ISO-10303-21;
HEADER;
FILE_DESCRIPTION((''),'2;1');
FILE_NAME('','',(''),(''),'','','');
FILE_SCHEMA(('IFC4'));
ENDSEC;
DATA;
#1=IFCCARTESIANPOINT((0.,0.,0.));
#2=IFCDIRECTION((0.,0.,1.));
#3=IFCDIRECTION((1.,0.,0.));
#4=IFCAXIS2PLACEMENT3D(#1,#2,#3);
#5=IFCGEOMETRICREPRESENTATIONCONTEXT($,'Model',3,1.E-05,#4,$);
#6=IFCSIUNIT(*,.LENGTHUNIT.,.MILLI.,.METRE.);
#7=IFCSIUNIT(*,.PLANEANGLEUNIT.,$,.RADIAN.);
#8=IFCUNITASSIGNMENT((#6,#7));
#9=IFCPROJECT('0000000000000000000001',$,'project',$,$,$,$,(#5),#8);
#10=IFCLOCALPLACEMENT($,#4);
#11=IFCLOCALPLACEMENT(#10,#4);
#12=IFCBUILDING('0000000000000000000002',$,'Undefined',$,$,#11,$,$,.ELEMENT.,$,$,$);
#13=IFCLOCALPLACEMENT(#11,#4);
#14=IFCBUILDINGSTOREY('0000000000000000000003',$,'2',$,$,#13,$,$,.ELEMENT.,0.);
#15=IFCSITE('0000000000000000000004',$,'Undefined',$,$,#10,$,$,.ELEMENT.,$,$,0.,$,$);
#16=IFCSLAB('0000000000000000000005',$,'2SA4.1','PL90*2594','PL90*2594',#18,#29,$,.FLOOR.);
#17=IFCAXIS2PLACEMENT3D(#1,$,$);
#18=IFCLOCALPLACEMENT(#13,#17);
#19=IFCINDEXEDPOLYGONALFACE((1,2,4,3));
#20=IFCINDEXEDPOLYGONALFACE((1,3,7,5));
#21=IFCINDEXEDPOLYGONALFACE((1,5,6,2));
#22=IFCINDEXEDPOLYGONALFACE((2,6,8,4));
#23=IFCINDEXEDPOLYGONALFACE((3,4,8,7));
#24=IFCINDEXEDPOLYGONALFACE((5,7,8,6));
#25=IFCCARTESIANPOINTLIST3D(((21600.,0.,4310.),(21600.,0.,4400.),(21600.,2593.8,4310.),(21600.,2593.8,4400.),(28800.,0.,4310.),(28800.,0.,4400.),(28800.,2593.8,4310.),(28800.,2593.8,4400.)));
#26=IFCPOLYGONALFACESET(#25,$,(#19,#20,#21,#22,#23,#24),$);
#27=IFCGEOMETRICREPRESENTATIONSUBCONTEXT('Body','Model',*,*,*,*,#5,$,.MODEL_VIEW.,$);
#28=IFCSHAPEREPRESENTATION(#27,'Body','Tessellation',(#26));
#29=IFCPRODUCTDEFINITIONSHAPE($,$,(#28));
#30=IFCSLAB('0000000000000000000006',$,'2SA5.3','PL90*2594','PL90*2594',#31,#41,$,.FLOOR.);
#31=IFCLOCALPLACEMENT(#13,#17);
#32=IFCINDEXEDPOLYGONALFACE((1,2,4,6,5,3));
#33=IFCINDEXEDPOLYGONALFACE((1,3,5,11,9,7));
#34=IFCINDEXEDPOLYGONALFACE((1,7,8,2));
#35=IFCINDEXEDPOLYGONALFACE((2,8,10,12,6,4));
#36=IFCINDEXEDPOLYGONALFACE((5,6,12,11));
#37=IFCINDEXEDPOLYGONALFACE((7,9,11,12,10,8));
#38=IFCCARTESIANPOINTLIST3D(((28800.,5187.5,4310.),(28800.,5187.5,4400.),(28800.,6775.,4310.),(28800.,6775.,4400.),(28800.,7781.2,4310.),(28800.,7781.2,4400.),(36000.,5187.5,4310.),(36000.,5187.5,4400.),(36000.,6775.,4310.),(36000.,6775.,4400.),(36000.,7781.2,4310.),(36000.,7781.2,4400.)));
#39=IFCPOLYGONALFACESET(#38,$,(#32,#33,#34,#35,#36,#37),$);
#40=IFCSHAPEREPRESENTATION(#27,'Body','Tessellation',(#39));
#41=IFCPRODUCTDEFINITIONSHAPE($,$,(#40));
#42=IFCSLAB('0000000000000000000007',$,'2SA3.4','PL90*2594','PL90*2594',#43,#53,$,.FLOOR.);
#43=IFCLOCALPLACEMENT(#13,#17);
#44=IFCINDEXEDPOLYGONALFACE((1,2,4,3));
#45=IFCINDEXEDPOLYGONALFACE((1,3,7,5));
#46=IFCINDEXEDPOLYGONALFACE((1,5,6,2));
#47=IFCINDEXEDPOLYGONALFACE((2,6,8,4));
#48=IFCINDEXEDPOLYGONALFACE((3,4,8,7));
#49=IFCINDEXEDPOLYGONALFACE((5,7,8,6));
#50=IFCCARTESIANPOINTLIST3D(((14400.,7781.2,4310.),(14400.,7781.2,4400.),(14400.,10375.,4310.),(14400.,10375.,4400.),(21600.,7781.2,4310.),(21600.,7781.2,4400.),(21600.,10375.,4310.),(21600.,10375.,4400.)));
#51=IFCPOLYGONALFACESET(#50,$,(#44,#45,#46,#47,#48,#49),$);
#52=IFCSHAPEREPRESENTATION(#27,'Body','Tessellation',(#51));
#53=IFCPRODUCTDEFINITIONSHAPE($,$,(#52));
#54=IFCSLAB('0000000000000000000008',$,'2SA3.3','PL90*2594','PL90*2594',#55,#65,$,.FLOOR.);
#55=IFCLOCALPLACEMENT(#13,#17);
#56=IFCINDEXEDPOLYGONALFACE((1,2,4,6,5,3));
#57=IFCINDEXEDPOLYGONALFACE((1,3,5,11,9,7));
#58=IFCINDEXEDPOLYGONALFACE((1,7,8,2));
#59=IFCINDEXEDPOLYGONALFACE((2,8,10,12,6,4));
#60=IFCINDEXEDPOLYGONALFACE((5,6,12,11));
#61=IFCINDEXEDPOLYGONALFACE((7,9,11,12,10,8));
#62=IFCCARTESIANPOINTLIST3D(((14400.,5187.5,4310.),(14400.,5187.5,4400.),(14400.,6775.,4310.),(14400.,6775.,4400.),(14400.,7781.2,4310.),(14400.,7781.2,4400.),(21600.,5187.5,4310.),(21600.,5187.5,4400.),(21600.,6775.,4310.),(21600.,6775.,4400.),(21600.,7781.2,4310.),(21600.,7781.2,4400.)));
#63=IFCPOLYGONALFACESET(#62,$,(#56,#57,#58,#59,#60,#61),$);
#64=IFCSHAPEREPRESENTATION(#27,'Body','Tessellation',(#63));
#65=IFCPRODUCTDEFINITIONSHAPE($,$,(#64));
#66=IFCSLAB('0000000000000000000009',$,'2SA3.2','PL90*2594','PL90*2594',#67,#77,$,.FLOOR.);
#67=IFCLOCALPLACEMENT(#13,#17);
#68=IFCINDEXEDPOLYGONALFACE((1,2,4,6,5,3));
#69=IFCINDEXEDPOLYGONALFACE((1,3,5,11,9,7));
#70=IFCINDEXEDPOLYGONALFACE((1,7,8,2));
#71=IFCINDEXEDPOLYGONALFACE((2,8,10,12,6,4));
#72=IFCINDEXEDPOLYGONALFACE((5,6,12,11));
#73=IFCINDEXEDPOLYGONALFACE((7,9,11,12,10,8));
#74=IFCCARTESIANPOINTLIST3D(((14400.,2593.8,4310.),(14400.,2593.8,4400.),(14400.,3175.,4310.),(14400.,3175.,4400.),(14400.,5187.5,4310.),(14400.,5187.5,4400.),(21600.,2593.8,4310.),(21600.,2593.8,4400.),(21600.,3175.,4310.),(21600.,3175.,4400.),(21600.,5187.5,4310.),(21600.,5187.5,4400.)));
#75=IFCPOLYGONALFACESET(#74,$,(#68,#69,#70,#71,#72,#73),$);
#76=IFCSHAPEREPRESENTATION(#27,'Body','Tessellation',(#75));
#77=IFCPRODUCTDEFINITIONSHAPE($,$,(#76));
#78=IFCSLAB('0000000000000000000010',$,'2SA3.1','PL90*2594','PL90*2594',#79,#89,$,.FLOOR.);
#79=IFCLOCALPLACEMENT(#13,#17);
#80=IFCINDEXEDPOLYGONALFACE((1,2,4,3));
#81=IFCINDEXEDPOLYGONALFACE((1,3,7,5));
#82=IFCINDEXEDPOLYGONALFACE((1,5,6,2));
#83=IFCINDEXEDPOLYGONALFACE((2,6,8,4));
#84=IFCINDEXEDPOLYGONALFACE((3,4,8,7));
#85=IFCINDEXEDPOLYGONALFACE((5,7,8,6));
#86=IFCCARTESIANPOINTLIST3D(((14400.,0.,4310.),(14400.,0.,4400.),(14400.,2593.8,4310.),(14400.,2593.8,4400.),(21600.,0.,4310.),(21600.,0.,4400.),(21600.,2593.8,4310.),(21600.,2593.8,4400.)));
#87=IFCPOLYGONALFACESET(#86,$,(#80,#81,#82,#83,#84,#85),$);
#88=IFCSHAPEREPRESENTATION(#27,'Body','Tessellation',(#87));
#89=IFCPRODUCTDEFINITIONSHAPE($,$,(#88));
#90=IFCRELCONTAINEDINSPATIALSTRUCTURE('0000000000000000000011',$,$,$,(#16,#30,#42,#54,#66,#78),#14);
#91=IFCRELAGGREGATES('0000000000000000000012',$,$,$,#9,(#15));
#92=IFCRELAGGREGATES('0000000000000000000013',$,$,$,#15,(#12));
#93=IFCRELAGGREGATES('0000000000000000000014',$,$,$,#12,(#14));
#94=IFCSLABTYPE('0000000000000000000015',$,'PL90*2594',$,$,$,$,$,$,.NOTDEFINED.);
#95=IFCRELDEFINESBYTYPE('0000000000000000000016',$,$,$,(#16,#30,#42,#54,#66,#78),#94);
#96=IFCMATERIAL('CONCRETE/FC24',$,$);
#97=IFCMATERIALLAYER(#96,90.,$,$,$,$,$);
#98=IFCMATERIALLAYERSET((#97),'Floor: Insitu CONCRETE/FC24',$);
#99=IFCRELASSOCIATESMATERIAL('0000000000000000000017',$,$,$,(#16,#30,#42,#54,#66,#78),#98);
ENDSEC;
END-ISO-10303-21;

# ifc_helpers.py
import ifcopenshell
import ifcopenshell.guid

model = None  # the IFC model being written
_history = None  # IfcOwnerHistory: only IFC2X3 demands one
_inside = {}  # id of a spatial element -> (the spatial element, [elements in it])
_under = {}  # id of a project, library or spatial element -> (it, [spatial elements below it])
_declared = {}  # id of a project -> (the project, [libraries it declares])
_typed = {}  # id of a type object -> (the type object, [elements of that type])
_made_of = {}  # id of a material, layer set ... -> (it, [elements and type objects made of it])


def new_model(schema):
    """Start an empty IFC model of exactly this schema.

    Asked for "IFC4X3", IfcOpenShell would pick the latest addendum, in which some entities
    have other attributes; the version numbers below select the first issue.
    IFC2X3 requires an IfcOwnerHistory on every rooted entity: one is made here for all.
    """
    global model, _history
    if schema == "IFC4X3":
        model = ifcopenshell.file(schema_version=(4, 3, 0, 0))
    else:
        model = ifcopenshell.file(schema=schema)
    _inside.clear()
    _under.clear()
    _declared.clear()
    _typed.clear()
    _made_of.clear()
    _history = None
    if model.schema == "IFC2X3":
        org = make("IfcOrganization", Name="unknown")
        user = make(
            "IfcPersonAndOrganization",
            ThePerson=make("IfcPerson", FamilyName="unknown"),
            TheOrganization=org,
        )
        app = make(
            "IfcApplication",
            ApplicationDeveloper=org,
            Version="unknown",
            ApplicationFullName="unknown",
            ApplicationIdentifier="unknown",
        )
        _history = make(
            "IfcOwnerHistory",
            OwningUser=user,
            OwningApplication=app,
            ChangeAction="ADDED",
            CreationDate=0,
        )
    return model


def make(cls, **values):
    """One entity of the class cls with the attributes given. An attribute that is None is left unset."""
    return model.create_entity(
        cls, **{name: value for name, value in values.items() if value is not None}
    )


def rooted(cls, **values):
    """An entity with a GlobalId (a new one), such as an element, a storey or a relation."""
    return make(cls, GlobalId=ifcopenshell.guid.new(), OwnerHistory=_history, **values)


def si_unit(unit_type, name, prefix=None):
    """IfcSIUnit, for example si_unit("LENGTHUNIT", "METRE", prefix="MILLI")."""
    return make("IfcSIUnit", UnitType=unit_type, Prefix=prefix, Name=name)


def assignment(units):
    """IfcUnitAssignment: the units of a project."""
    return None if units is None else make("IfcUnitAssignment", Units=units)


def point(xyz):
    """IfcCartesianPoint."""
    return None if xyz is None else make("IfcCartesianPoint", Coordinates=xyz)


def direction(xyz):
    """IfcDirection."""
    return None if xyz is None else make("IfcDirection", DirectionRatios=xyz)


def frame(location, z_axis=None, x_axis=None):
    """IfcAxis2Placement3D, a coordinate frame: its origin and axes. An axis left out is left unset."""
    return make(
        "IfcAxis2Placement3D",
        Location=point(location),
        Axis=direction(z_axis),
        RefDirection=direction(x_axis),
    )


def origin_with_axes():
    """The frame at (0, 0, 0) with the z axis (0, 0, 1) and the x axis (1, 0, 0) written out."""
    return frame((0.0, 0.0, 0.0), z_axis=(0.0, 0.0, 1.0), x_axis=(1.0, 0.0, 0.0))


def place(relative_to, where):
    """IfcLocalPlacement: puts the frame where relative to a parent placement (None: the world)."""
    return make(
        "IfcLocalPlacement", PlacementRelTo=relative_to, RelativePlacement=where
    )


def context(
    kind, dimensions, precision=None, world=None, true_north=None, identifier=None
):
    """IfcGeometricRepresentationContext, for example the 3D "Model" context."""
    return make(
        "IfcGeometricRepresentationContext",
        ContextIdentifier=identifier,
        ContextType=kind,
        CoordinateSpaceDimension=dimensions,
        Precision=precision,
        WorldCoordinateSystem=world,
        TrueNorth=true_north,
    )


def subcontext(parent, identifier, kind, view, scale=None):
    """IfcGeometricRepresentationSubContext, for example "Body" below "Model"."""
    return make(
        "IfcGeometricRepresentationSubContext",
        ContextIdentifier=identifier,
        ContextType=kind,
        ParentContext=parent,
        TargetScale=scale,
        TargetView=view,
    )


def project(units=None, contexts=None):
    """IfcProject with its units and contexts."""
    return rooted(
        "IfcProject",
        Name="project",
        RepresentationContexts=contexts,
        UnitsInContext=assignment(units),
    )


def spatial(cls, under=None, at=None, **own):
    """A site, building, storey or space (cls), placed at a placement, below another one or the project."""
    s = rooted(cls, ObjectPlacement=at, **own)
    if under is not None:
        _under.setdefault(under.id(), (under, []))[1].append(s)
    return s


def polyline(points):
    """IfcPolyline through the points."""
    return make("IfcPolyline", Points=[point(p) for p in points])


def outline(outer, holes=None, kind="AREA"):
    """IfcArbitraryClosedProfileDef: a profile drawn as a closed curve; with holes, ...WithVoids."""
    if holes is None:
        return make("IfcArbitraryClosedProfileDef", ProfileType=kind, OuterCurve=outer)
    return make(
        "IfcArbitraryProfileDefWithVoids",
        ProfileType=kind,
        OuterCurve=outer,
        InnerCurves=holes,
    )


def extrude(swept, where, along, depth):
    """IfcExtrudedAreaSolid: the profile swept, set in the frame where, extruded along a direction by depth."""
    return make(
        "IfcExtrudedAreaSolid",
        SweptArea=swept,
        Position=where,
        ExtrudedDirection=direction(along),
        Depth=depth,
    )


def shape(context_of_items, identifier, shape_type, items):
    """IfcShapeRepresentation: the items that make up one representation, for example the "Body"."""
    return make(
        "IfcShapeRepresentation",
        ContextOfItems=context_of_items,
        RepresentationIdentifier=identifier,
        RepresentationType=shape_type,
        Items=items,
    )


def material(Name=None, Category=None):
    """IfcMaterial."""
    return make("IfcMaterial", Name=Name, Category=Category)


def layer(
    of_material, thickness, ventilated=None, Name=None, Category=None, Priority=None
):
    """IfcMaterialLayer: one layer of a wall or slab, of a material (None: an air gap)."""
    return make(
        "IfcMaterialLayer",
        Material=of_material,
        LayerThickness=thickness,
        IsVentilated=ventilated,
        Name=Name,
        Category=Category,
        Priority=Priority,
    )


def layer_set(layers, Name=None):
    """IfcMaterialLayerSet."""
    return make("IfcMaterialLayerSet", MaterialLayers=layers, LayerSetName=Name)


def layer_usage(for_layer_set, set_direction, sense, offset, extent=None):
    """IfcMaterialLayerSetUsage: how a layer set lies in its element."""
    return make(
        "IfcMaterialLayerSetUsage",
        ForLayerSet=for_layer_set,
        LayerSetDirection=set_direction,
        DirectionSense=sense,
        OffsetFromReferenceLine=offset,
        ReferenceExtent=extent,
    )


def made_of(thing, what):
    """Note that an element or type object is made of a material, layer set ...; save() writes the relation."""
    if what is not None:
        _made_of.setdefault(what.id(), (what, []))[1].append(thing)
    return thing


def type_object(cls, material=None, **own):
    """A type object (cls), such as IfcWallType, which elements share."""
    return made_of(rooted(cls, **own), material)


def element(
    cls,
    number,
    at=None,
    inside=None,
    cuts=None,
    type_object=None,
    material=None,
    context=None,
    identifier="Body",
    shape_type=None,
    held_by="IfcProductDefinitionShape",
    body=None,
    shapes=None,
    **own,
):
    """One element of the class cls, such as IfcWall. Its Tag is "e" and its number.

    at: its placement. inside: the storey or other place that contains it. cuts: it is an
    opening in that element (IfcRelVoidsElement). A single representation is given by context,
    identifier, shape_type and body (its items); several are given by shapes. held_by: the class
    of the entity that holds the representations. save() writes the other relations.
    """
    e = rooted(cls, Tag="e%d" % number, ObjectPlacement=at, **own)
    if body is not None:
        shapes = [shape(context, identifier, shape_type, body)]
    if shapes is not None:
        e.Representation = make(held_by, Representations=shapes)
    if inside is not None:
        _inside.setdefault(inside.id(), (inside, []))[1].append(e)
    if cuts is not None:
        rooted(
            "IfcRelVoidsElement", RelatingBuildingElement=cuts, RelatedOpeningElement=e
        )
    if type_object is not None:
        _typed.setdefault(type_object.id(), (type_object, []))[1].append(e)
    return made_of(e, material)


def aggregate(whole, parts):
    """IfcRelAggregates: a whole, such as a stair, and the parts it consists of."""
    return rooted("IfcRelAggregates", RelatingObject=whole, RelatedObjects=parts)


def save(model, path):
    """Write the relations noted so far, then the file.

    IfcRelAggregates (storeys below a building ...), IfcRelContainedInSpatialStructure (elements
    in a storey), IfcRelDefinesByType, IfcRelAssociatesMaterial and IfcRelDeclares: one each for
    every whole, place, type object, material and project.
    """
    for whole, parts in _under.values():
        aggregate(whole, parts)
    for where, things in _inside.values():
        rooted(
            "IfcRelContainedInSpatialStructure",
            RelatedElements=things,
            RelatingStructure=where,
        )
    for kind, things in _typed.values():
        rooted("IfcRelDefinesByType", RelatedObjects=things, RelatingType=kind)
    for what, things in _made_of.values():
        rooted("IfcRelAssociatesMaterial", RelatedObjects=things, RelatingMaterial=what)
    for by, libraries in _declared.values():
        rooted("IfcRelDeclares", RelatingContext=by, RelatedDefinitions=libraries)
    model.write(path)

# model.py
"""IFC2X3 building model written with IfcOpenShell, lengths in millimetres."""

from ifc_helpers import new_model, si_unit, frame, origin_with_axes, place, context, subcontext, project, spatial, polyline, outline, extrude, material, layer, layer_set, layer_usage, type_object, element, save


model = new_model("IFC2X3")

# Units and contexts
model_context = context("Model", 3, precision=1e-05, world=origin_with_axes())
body_context = subcontext(model_context, "Body", "Model", "MODEL_VIEW")
ifc_project = project(units=[si_unit("LENGTHUNIT", "METRE", prefix="MILLI"), si_unit("PLANEANGLEUNIT", "RADIAN")], contexts=[model_context])

# Site, building, storey
site_placement = place(None, origin_with_axes())
site = spatial("IfcSite", under=ifc_project, at=site_placement, Name="Undefined", CompositionType="ELEMENT", RefElevation=0.0)
building_placement = place(site_placement, origin_with_axes())
building = spatial("IfcBuilding", under=site, at=building_placement, Name="Undefined", CompositionType="ELEMENT")
storey_placement = place(building_placement, origin_with_axes())
storey = spatial("IfcBuildingStorey", under=building, at=storey_placement, Name="2", CompositionType="ELEMENT", Elevation=0.0)

# Slabs
ifc_material_1 = material(Name="CONCRETE/FC24")
ifc_layer = layer(ifc_material_1, 90.0)
ifc_layer_set = layer_set([ifc_layer], Name="Floor: Insitu CONCRETE/FC24")
slab_type = type_object("IfcSlabType", Name="PL90*2594", PredefinedType="NOTDEFINED")
ifc_layer_usage_1 = layer_usage(ifc_layer_set, "AXIS3", "POSITIVE", -45.0)
slab_1_placement = place(storey_placement, frame((21600.0, 0.0, 4355.0), z_axis=(0.0, 0.0, 1.0), x_axis=(1.0, 0.0, 0.0)))
element("IfcSlab", 1, at=slab_1_placement, inside=storey, type_object=slab_type, material=ifc_layer_usage_1, Name="2SA4.1", Description="PL90*2594", ObjectType="PL90*2594", PredefinedType="FLOOR", context=body_context, shape_type="SweptSolid", body=[
    extrude(outline(polyline([(0.0, 0.0), (7200.0, 0.0), (7200.0, 2593.8), (0.0, 2593.8), (0.0, 0.0)])), frame((0.0, 0.0, -45.0), z_axis=(0.0, 0.0, 1.0), x_axis=(1.0, 0.0, 0.0)), (0.0, 0.0, 1.0), 90.0),
])
ifc_layer_usage_2 = layer_usage(ifc_layer_set, "AXIS3", "POSITIVE", -45.0)
slab_2_placement = place(storey_placement, frame((28800.0, 5187.5, 4355.0), z_axis=(0.0, 0.0, 1.0), x_axis=(1.0, 0.0, 0.0)))
element("IfcSlab", 2, at=slab_2_placement, inside=storey, type_object=slab_type, material=ifc_layer_usage_2, Name="2SA5.3", Description="PL90*2594", ObjectType="PL90*2594", PredefinedType="FLOOR", context=body_context, shape_type="SweptSolid", body=[
    extrude(outline(polyline([(0.0, 0.0), (7200.0, 0.0), (7200.0, 1587.5), (7200.0, 2593.8), (0.0, 2593.8), (0.0, 1587.5), (0.0, 0.0)])), frame((0.0, 0.0, -45.0), z_axis=(0.0, 0.0, 1.0), x_axis=(1.0, 0.0, 0.0)), (0.0, 0.0, 1.0), 90.0),
])
ifc_layer_usage_3 = layer_usage(ifc_layer_set, "AXIS3", "POSITIVE", -45.0)
slab_3_placement = place(storey_placement, frame((14400.0, 7781.2, 4355.0), z_axis=(0.0, 0.0, 1.0), x_axis=(1.0, 0.0, 0.0)))
element("IfcSlab", 3, at=slab_3_placement, inside=storey, type_object=slab_type, material=ifc_layer_usage_3, Name="2SA3.4", Description="PL90*2594", ObjectType="PL90*2594", PredefinedType="FLOOR", context=body_context, shape_type="SweptSolid", body=[
    extrude(outline(polyline([(0.0, 0.0), (7200.0, 0.0), (7200.0, 2593.8), (0.0, 2593.8), (0.0, 0.0)])), frame((0.0, 0.0, -45.0), z_axis=(0.0, 0.0, 1.0), x_axis=(1.0, 0.0, 0.0)), (0.0, 0.0, 1.0), 90.0),
])
ifc_layer_usage_4 = layer_usage(ifc_layer_set, "AXIS3", "POSITIVE", -45.0)
slab_4_placement = place(storey_placement, frame((14400.0, 5187.5, 4355.0), z_axis=(0.0, 0.0, 1.0), x_axis=(1.0, 0.0, 0.0)))
element("IfcSlab", 4, at=slab_4_placement, inside=storey, type_object=slab_type, material=ifc_layer_usage_4, Name="2SA3.3", Description="PL90*2594", ObjectType="PL90*2594", PredefinedType="FLOOR", context=body_context, shape_type="SweptSolid", body=[
    extrude(outline(polyline([(0.0, 0.0), (7200.0, 0.0), (7200.0, 1587.5), (7200.0, 2593.8), (0.0, 2593.8), (0.0, 1587.5), (0.0, 0.0)])), frame((0.0, 0.0, -45.0), z_axis=(0.0, 0.0, 1.0), x_axis=(1.0, 0.0, 0.0)), (0.0, 0.0, 1.0), 90.0),
])
ifc_layer_usage_5 = layer_usage(ifc_layer_set, "AXIS3", "POSITIVE", -45.0)
slab_5_placement = place(storey_placement, frame((14400.0, 2593.8, 4355.0), z_axis=(0.0, 0.0, 1.0), x_axis=(1.0, 0.0, 0.0)))
element("IfcSlab", 5, at=slab_5_placement, inside=storey, type_object=slab_type, material=ifc_layer_usage_5, Name="2SA3.2", Description="PL90*2594", ObjectType="PL90*2594", PredefinedType="FLOOR", context=body_context, shape_type="SweptSolid", body=[
    extrude(outline(polyline([(0.0, 0.0), (7200.0, 0.0), (7200.0, 581.2), (7200.0, 2593.8), (0.0, 2593.8), (0.0, 581.2), (0.0, 0.0)])), frame((0.0, 0.0, -45.0), z_axis=(0.0, 0.0, 1.0), x_axis=(1.0, 0.0, 0.0)), (0.0, 0.0, 1.0), 90.0),
])
ifc_layer_usage_6 = layer_usage(ifc_layer_set, "AXIS3", "POSITIVE", -45.0)
slab_6_placement = place(storey_placement, frame((14400.0, 0.0, 4355.0), z_axis=(0.0, 0.0, 1.0), x_axis=(1.0, 0.0, 0.0)))
element("IfcSlab", 6, at=slab_6_placement, inside=storey, type_object=slab_type, material=ifc_layer_usage_6, Name="2SA3.1", Description="PL90*2594", ObjectType="PL90*2594", PredefinedType="FLOOR", context=body_context, shape_type="SweptSolid", body=[
    extrude(outline(polyline([(0.0, 0.0), (7200.0, 0.0), (7200.0, 2593.8), (0.0, 2593.8), (0.0, 0.0)])), frame((0.0, 0.0, -45.0), z_axis=(0.0, 0.0, 1.0), x_axis=(1.0, 0.0, 0.0)), (0.0, 0.0, 1.0), 90.0),
])

save(model, "model.ifc")
